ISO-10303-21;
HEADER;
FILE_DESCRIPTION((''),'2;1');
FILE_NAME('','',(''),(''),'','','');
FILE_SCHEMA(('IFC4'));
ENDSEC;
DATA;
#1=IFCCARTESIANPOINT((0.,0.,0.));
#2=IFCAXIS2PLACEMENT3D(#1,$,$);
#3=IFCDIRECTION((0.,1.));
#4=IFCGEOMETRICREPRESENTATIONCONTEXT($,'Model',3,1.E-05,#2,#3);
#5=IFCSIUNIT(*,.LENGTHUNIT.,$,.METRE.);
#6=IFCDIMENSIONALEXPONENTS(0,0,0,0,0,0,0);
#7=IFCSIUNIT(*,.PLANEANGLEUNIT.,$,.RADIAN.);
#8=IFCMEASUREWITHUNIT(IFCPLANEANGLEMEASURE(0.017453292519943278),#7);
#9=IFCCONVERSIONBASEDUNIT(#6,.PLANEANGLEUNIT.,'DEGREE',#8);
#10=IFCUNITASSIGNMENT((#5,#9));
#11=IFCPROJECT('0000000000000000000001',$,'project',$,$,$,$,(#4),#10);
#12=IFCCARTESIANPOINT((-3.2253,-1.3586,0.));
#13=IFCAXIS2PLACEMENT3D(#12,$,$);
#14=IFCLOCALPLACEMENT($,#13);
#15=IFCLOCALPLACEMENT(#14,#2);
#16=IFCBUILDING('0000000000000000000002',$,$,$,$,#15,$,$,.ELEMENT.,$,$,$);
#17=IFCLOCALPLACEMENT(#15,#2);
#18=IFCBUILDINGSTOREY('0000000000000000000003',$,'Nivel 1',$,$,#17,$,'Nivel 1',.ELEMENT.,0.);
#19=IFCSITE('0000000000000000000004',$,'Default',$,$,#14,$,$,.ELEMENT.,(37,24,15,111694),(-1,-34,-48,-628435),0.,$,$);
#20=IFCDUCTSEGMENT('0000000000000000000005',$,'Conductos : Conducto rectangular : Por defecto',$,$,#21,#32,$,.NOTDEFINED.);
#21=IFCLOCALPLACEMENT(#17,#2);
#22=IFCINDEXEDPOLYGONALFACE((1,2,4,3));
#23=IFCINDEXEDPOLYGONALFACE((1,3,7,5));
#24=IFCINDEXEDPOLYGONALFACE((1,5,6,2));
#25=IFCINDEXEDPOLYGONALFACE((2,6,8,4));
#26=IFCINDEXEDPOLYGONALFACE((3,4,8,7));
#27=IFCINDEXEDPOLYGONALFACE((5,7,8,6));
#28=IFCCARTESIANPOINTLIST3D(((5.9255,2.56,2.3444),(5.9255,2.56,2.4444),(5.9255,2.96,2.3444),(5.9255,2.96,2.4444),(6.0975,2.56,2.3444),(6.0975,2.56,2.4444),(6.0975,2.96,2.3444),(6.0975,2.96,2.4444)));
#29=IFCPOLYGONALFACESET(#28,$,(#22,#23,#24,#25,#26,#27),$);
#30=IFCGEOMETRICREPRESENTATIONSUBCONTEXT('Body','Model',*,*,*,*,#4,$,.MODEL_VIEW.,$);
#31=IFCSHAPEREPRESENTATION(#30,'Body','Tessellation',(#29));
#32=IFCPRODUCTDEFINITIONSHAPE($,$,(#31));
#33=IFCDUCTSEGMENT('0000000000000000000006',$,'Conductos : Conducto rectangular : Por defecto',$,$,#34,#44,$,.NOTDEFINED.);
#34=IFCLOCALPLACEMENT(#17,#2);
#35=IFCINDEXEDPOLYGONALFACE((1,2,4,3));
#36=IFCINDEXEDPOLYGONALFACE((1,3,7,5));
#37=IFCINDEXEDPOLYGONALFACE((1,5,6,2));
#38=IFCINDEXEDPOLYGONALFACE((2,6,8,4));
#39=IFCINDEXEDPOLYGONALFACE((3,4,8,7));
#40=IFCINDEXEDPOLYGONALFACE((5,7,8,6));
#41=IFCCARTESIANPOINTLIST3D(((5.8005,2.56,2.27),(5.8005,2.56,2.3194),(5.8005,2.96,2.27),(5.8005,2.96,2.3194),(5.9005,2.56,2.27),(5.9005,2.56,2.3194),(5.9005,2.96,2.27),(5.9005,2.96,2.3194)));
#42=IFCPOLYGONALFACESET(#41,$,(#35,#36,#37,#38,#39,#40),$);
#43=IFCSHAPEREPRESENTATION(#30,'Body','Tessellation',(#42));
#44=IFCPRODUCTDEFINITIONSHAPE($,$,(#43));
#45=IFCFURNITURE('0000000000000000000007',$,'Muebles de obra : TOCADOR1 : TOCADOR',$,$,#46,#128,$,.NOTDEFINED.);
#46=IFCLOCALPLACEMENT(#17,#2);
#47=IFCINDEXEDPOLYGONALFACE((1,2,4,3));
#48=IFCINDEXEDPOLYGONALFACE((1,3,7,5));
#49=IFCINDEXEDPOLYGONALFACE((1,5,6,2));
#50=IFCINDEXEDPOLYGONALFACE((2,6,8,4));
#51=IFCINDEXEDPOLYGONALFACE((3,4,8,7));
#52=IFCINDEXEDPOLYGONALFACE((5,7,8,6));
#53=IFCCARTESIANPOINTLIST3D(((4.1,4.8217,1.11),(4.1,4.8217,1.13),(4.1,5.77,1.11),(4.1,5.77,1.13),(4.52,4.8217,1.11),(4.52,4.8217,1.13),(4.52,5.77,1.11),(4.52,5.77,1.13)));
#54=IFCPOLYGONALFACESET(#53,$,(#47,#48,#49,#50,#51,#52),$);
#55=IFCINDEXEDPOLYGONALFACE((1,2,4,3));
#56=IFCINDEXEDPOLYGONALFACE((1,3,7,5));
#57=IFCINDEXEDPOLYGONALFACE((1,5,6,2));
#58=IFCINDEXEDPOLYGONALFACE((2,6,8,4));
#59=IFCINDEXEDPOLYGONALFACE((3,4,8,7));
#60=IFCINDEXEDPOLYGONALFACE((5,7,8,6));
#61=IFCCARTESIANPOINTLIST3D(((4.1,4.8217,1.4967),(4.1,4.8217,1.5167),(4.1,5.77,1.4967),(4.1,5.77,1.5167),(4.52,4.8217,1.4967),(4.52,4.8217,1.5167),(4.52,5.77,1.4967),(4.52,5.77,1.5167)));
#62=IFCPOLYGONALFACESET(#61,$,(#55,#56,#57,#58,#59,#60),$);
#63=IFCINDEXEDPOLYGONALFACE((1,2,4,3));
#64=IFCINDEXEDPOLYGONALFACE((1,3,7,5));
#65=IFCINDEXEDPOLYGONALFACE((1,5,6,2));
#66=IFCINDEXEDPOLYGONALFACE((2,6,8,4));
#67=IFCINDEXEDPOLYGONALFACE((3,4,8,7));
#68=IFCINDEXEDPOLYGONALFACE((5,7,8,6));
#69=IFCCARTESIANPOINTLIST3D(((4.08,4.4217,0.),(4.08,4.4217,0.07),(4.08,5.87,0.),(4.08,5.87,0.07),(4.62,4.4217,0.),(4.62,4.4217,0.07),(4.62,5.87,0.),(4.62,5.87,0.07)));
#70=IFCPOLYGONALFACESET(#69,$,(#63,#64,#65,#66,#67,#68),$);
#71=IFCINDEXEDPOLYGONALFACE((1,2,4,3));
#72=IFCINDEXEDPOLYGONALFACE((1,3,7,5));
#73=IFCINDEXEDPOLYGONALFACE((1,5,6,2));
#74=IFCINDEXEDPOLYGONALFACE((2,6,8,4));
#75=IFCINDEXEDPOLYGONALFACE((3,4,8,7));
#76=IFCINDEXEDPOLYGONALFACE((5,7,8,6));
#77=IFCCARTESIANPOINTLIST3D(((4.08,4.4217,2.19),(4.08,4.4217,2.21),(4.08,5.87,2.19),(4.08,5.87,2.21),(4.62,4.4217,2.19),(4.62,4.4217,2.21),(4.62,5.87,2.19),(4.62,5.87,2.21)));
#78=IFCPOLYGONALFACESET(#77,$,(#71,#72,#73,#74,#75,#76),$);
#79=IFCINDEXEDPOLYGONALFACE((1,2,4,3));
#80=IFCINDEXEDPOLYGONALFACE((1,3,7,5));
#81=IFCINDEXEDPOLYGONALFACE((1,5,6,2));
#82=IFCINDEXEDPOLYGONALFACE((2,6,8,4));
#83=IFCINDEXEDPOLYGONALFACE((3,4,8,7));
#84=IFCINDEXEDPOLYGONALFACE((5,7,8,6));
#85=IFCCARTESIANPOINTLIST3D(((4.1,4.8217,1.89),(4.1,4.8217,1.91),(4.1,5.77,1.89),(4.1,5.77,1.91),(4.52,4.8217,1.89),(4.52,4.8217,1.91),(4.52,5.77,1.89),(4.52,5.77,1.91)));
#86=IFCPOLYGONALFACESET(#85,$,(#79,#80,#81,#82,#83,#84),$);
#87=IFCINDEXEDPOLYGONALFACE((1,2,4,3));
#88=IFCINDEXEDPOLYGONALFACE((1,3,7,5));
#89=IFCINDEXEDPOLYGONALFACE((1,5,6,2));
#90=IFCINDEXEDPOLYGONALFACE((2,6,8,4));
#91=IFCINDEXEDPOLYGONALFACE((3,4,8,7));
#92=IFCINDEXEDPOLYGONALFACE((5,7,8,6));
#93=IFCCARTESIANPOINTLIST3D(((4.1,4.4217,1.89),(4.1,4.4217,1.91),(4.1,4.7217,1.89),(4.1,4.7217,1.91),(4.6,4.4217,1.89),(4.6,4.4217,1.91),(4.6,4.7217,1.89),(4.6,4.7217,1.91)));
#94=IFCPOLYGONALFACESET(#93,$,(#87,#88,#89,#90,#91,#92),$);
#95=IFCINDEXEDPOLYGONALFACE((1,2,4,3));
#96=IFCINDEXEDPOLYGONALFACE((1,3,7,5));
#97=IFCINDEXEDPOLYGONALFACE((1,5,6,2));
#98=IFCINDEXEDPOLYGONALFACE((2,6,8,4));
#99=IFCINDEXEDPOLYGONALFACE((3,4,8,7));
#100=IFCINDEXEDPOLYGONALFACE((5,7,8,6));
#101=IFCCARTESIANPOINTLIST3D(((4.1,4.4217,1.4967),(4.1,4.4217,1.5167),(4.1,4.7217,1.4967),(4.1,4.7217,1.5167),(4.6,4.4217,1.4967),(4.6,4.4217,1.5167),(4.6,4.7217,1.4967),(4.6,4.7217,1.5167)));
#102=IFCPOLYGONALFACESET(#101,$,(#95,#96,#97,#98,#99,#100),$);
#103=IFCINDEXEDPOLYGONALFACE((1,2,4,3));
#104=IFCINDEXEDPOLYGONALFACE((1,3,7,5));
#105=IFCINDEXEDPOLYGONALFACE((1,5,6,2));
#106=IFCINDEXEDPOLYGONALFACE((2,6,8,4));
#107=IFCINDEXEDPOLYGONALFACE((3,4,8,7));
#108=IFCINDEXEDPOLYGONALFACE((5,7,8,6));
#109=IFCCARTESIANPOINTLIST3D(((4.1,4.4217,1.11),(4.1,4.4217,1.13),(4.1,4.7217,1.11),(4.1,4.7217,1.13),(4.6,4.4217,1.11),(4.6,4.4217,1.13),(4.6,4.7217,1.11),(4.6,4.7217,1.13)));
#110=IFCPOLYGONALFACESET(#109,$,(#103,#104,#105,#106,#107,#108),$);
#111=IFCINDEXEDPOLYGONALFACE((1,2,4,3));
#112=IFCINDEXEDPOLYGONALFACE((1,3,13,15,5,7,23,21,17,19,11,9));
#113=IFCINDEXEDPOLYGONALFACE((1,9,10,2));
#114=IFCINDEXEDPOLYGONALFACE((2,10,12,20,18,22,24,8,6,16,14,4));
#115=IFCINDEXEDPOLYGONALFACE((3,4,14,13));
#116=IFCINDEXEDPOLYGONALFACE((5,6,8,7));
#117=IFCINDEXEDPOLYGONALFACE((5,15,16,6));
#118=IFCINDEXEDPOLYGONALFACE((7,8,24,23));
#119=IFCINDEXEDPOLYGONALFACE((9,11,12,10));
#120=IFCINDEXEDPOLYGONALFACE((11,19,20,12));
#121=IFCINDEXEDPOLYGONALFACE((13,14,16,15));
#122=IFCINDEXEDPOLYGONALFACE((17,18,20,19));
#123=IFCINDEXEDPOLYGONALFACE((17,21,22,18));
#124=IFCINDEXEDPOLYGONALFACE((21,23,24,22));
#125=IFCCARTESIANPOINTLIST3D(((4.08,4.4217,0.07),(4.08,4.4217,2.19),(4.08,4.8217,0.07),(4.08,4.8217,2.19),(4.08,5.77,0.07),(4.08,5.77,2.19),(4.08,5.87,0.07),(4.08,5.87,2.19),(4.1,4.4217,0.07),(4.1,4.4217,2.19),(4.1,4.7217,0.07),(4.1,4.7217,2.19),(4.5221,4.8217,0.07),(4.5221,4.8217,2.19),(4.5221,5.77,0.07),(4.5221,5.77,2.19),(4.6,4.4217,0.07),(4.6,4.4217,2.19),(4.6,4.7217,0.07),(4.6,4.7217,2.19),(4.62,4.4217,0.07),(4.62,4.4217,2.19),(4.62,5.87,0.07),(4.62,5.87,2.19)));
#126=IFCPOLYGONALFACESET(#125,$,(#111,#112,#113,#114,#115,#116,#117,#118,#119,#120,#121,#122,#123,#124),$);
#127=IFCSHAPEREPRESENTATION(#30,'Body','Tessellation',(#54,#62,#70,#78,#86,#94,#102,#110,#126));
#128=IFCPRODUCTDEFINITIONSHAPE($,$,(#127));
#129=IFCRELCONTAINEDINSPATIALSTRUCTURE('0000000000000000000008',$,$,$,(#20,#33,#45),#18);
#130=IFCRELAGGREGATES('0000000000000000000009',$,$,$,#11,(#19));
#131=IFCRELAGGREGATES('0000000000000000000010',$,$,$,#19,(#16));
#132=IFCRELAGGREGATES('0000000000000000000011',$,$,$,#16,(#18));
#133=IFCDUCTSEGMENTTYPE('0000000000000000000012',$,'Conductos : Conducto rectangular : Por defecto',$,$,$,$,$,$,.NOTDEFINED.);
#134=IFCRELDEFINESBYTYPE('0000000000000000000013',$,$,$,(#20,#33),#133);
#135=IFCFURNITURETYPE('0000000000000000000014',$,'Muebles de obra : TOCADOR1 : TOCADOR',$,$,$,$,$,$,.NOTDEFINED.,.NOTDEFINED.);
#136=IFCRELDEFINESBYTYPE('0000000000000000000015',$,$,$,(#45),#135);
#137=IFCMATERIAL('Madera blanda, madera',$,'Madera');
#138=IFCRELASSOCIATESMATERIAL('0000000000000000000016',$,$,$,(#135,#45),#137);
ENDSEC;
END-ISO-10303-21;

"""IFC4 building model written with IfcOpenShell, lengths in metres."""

from ifc_helpers import new_model, entity, si_unit, converted_unit, direction, frame, origin, place, context, subcontext, project, spatial, indexed_curve, outline, extrude, source, transform, mapped, material, type_object, type_shapes, element, save


model = new_model("IFC4")

# Units and contexts
model_context = context("Model", 3, precision=1e-05, world=origin(), true_north=direction((0.0, 1.0)))
body_context = subcontext(model_context, "Body", "Model", "MODEL_VIEW")
ifc_project = project(units=[si_unit("LENGTHUNIT", "METRE"), converted_unit("PLANEANGLEUNIT", "DEGREE", entity("IfcPlaneAngleMeasure", 0.017453292519943278), si_unit("PLANEANGLEUNIT", "RADIAN"), dimensions=[0, 0, 0, 0, 0, 0, 0])], contexts=[model_context])

# Site, building, storey
site_placement = place(None, frame((-3.2253, -1.3586, 0.0)))
site = spatial("IfcSite", under=ifc_project, at=site_placement, Name="Default", CompositionType="ELEMENT", RefLatitude=(37, 24, 15, 111694), RefLongitude=(-1, -34, -48, -628435), RefElevation=0.0)
building_placement = place(site_placement, origin())
building = spatial("IfcBuilding", under=site, at=building_placement, CompositionType="ELEMENT")
storey_placement = place(building_placement, origin())
storey = spatial("IfcBuildingStorey", under=building, at=storey_placement, Name="Nivel 1", LongName="Nivel 1", CompositionType="ELEMENT", Elevation=0.0)

# Shared definitions
ifc_material_1 = material(Name="Madera blanda, madera", Category="Madera")

# Duct segments
duct_segment_type = type_object("IfcDuctSegmentType", Name="Conductos : Conducto rectangular : Por defecto", PredefinedType="NOTDEFINED")
duct_segment_1_placement = place(storey_placement, origin())
element("IfcDuctSegment", 1, at=duct_segment_1_placement, inside=storey, type_object=duct_segment_type, Name="Conductos : Conducto rectangular : Por defecto", PredefinedType="NOTDEFINED", context=body_context, shape_type="SweptSolid", body=[
    extrude(outline(indexed_curve([(-0.086, -0.2), (0.086, -0.2), (0.086, 0.2), (-0.086, 0.2), (-0.086, -0.2)], self_intersect=False)), frame((6.0115, 2.76, 2.3444), z_axis=(0.0, 0.0, 1.0), x_axis=(-1.0, 0.0, 0.0)), (0.0, 0.0, 1.0), 0.1),
])
duct_segment_2_placement = place(storey_placement, origin())
element("IfcDuctSegment", 2, at=duct_segment_2_placement, inside=storey, type_object=duct_segment_type, Name="Conductos : Conducto rectangular : Por defecto", PredefinedType="NOTDEFINED", context=body_context, shape_type="SweptSolid", body=[
    extrude(outline(indexed_curve([(-0.2, -0.05), (0.2, -0.05), (0.2, 0.05), (-0.2, 0.05), (-0.2, -0.05)], self_intersect=False)), frame((5.8505, 2.76, 2.27), z_axis=(0.0, 0.0, 1.0), x_axis=(0.0, 1.0, 0.0)), (0.0, 0.0, 1.0), 0.0494),
])

# Furniture
furniture_type_1 = type_object("IfcFurnitureType", Name="Muebles de obra : TOCADOR1 : TOCADOR", AssemblyPlace="NOTDEFINED", PredefinedType="NOTDEFINED", material=ifc_material_1)
shared_shape_1 = source(origin(), body_context, "Body", "SweptSolid", [
    extrude(outline(indexed_curve([(-0.21, -0.4741), (0.21, -0.4741), (0.21, 0.4741), (-0.21, 0.4741), (-0.21, -0.4741)], self_intersect=False)), frame((4.31, 5.2959, 1.11), z_axis=(0.0, 0.0, 1.0), x_axis=(-1.0, 0.0, 0.0)), (0.0, 0.0, 1.0), 0.02),
    extrude(outline(indexed_curve([(-0.21, -0.4741), (0.21, -0.4741), (0.21, 0.4741), (-0.21, 0.4741), (-0.21, -0.4741)], self_intersect=False)), frame((4.31, 5.2959, 1.4967), z_axis=(0.0, 0.0, 1.0), x_axis=(-1.0, 0.0, 0.0)), (0.0, 0.0, 1.0), 0.02),
    extrude(outline(indexed_curve([(-0.27, -0.7241), (0.27, -0.7241), (0.27, 0.7241), (-0.27, 0.7241), (-0.27, -0.7241)], self_intersect=False)), frame((4.35, 5.1459, 0.0)), (0.0, 0.0, 1.0), 0.07),
    extrude(outline(indexed_curve([(-0.27, -0.7241), (0.27, -0.7241), (0.27, 0.7241), (-0.27, 0.7241), (-0.27, -0.7241)], self_intersect=False)), frame((4.35, 5.1459, 2.19), z_axis=(0.0, 0.0, 1.0), x_axis=(-1.0, 0.0, 0.0)), (0.0, 0.0, 1.0), 0.02),
    extrude(outline(indexed_curve([(-0.21, -0.4741), (0.21, -0.4741), (0.21, 0.4741), (-0.21, 0.4741), (-0.21, -0.4741)], self_intersect=False)), frame((4.31, 5.2959, 1.89), z_axis=(0.0, 0.0, 1.0), x_axis=(-1.0, 0.0, 0.0)), (0.0, 0.0, 1.0), 0.02),
    extrude(outline(indexed_curve([(-0.25, -0.15), (0.25, -0.15), (0.25, 0.15), (-0.25, 0.15), (-0.25, -0.15)], self_intersect=False)), frame((4.35, 4.5717, 1.89), z_axis=(0.0, 0.0, 1.0), x_axis=(-1.0, 0.0, 0.0)), (0.0, 0.0, 1.0), 0.02),
    extrude(outline(indexed_curve([(-0.25, -0.15), (0.25, -0.15), (0.25, 0.15), (-0.25, 0.15), (-0.25, -0.15)], self_intersect=False)), frame((4.35, 4.5717, 1.4967), z_axis=(0.0, 0.0, 1.0), x_axis=(-1.0, 0.0, 0.0)), (0.0, 0.0, 1.0), 0.02),
    extrude(outline(indexed_curve([(-0.25, -0.15), (0.25, -0.15), (0.25, 0.15), (-0.25, 0.15), (-0.25, -0.15)], self_intersect=False)), frame((4.35, 4.5717, 1.11), z_axis=(0.0, 0.0, 1.0), x_axis=(-1.0, 0.0, 0.0)), (0.0, 0.0, 1.0), 0.02),
    extrude(outline(indexed_curve([(-0.2863, -0.8655), (0.2537, -0.8655), (0.2537, -0.7655), (-0.1884, -0.7655), (-0.1884, 0.1828), (0.2537, 0.1828), (0.2537, 0.5828), (0.2337, 0.5828), (0.2337, 0.2828), (-0.2663, 0.2828), (-0.2663, 0.5828), (-0.2863, 0.5828), (-0.2863, -0.8655)], self_intersect=False)), frame((4.3337, 5.0045, 0.07), z_axis=(0.0, 0.0, 1.0), x_axis=(-1.0, 0.0, 0.0)), (0.0, 0.0, 1.0), 2.12),
])
type_shapes(furniture_type_1, [shared_shape_1])
furniture_1_placement = place(storey_placement, origin())
element("IfcFurniture", 3, at=furniture_1_placement, inside=storey, type_object=furniture_type_1, material=ifc_material_1, Name="Muebles de obra : TOCADOR1 : TOCADOR", PredefinedType="NOTDEFINED", context=body_context, shape_type="MappedRepresentation", body=[
    mapped(shared_shape_1, transform((0.0, 0.0, 0.0), scale=1.0)),
])

save(model, "model.ifc")
